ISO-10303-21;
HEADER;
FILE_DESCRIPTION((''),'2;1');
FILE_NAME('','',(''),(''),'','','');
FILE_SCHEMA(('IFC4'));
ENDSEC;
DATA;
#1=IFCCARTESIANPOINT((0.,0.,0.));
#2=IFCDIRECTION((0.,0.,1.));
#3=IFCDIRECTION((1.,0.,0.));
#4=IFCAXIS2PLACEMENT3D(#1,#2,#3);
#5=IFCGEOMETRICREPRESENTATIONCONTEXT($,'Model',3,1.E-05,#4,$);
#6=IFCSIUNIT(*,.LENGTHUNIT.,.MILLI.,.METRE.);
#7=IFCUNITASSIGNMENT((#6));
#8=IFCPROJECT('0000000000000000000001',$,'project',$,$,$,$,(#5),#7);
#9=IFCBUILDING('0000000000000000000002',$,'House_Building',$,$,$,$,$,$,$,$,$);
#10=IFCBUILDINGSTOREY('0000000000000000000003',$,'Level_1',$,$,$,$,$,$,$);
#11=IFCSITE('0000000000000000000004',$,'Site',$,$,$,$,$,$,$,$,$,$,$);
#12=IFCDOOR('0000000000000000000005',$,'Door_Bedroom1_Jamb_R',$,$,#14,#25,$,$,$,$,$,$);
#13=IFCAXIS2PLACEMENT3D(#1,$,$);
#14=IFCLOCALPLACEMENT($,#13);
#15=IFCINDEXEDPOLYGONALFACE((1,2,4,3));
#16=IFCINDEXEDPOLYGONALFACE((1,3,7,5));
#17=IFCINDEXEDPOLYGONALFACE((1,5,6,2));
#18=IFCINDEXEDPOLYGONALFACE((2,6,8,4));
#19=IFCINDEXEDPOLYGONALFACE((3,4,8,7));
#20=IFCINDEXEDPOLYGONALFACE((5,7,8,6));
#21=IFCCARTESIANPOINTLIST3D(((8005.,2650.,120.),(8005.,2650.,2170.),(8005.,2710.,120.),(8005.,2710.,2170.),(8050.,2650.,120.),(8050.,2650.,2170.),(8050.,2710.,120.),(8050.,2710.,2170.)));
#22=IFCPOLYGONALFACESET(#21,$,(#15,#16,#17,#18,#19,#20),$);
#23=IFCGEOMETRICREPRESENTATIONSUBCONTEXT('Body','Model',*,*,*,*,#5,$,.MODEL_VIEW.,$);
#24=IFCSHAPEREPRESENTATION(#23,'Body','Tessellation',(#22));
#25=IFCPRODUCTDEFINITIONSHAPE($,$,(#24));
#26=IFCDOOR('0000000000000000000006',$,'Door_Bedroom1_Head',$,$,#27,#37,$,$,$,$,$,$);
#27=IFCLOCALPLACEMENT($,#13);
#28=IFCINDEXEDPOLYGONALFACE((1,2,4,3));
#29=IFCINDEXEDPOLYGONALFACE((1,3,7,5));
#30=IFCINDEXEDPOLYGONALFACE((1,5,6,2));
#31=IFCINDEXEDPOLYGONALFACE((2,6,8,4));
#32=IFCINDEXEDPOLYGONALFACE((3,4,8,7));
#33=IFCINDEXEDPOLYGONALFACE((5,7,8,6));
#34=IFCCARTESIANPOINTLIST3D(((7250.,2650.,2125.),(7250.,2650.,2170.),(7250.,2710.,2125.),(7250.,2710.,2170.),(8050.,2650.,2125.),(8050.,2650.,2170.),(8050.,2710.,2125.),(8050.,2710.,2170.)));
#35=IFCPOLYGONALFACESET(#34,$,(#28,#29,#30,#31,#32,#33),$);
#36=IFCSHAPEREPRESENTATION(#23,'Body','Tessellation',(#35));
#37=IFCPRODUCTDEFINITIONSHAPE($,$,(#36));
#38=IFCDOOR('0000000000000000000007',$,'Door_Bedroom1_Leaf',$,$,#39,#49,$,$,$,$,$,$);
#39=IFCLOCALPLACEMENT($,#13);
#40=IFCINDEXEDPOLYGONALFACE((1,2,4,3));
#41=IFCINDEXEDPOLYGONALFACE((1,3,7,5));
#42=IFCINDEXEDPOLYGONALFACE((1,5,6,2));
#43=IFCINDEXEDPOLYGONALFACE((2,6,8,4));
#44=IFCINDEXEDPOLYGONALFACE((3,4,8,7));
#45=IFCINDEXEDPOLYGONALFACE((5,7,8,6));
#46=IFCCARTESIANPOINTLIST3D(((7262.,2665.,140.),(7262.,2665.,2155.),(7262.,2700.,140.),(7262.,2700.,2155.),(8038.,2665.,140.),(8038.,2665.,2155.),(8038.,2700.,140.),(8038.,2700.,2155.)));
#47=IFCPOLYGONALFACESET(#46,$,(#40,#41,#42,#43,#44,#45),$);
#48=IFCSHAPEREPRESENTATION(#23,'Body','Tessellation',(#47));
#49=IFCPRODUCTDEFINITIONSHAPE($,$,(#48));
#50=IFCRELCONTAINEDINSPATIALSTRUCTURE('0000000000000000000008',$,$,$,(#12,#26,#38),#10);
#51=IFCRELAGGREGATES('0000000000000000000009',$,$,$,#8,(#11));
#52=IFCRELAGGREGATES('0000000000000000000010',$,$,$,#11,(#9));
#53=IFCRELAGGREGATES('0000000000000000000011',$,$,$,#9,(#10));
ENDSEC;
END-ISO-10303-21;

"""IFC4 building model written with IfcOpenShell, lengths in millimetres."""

from ifc_helpers import new_model, si_unit, frame, origin_with_axes, context, subcontext, project, spatial, polyline, outline, extrude, element, save


model = new_model("IFC4")

# Units and contexts
model_context = context("Model", 3, precision=1e-05, world=origin_with_axes())
body_context = subcontext(model_context, "Body", "Model", "MODEL_VIEW")
ifc_project = project(units=[si_unit("LENGTHUNIT", "METRE", prefix="MILLI")], contexts=[model_context])

# Site, building, storey
site = spatial("IfcSite", under=ifc_project, Name="Site")
building = spatial("IfcBuilding", under=site, Name="House_Building")
storey = spatial("IfcBuildingStorey", under=building, Name="Level_1")

# Doors
element("IfcDoor", 1, inside=storey, Name="Door_Bedroom1_Jamb_R", context=body_context, shape_type="SweptSolid", body=[
    extrude(outline(polyline([(8005.0, 2650.0), (8050.0, 2650.0), (8050.0, 2710.0), (8005.0, 2710.0), (8005.0, 2650.0)])), frame((0.0, 0.0, 120.0), z_axis=(0.0, 0.0, 1.0), x_axis=(1.0, 0.0, 0.0)), (0.0, 0.0, 1.0), 2050.0),
])
element("IfcDoor", 2, inside=storey, Name="Door_Bedroom1_Head", context=body_context, shape_type="SweptSolid", body=[
    extrude(outline(polyline([(7250.0, 2650.0), (8050.0, 2650.0), (8050.0, 2710.0), (7250.0, 2710.0), (7250.0, 2650.0)])), frame((0.0, 0.0, 2125.0), z_axis=(0.0, 0.0, 1.0), x_axis=(1.0, 0.0, 0.0)), (0.0, 0.0, 1.0), 45.0),
])
element("IfcDoor", 3, inside=storey, Name="Door_Bedroom1_Leaf", context=body_context, shape_type="SweptSolid", body=[
    extrude(outline(polyline([(7262.0, 2665.0), (8038.0, 2665.0), (8038.0, 2700.0), (7262.0, 2700.0), (7262.0, 2665.0)])), frame((0.0, 0.0, 140.0), z_axis=(0.0, 0.0, 1.0), x_axis=(1.0, 0.0, 0.0)), (0.0, 0.0, 1.0), 2015.0),
])

save(model, "model.ifc")
